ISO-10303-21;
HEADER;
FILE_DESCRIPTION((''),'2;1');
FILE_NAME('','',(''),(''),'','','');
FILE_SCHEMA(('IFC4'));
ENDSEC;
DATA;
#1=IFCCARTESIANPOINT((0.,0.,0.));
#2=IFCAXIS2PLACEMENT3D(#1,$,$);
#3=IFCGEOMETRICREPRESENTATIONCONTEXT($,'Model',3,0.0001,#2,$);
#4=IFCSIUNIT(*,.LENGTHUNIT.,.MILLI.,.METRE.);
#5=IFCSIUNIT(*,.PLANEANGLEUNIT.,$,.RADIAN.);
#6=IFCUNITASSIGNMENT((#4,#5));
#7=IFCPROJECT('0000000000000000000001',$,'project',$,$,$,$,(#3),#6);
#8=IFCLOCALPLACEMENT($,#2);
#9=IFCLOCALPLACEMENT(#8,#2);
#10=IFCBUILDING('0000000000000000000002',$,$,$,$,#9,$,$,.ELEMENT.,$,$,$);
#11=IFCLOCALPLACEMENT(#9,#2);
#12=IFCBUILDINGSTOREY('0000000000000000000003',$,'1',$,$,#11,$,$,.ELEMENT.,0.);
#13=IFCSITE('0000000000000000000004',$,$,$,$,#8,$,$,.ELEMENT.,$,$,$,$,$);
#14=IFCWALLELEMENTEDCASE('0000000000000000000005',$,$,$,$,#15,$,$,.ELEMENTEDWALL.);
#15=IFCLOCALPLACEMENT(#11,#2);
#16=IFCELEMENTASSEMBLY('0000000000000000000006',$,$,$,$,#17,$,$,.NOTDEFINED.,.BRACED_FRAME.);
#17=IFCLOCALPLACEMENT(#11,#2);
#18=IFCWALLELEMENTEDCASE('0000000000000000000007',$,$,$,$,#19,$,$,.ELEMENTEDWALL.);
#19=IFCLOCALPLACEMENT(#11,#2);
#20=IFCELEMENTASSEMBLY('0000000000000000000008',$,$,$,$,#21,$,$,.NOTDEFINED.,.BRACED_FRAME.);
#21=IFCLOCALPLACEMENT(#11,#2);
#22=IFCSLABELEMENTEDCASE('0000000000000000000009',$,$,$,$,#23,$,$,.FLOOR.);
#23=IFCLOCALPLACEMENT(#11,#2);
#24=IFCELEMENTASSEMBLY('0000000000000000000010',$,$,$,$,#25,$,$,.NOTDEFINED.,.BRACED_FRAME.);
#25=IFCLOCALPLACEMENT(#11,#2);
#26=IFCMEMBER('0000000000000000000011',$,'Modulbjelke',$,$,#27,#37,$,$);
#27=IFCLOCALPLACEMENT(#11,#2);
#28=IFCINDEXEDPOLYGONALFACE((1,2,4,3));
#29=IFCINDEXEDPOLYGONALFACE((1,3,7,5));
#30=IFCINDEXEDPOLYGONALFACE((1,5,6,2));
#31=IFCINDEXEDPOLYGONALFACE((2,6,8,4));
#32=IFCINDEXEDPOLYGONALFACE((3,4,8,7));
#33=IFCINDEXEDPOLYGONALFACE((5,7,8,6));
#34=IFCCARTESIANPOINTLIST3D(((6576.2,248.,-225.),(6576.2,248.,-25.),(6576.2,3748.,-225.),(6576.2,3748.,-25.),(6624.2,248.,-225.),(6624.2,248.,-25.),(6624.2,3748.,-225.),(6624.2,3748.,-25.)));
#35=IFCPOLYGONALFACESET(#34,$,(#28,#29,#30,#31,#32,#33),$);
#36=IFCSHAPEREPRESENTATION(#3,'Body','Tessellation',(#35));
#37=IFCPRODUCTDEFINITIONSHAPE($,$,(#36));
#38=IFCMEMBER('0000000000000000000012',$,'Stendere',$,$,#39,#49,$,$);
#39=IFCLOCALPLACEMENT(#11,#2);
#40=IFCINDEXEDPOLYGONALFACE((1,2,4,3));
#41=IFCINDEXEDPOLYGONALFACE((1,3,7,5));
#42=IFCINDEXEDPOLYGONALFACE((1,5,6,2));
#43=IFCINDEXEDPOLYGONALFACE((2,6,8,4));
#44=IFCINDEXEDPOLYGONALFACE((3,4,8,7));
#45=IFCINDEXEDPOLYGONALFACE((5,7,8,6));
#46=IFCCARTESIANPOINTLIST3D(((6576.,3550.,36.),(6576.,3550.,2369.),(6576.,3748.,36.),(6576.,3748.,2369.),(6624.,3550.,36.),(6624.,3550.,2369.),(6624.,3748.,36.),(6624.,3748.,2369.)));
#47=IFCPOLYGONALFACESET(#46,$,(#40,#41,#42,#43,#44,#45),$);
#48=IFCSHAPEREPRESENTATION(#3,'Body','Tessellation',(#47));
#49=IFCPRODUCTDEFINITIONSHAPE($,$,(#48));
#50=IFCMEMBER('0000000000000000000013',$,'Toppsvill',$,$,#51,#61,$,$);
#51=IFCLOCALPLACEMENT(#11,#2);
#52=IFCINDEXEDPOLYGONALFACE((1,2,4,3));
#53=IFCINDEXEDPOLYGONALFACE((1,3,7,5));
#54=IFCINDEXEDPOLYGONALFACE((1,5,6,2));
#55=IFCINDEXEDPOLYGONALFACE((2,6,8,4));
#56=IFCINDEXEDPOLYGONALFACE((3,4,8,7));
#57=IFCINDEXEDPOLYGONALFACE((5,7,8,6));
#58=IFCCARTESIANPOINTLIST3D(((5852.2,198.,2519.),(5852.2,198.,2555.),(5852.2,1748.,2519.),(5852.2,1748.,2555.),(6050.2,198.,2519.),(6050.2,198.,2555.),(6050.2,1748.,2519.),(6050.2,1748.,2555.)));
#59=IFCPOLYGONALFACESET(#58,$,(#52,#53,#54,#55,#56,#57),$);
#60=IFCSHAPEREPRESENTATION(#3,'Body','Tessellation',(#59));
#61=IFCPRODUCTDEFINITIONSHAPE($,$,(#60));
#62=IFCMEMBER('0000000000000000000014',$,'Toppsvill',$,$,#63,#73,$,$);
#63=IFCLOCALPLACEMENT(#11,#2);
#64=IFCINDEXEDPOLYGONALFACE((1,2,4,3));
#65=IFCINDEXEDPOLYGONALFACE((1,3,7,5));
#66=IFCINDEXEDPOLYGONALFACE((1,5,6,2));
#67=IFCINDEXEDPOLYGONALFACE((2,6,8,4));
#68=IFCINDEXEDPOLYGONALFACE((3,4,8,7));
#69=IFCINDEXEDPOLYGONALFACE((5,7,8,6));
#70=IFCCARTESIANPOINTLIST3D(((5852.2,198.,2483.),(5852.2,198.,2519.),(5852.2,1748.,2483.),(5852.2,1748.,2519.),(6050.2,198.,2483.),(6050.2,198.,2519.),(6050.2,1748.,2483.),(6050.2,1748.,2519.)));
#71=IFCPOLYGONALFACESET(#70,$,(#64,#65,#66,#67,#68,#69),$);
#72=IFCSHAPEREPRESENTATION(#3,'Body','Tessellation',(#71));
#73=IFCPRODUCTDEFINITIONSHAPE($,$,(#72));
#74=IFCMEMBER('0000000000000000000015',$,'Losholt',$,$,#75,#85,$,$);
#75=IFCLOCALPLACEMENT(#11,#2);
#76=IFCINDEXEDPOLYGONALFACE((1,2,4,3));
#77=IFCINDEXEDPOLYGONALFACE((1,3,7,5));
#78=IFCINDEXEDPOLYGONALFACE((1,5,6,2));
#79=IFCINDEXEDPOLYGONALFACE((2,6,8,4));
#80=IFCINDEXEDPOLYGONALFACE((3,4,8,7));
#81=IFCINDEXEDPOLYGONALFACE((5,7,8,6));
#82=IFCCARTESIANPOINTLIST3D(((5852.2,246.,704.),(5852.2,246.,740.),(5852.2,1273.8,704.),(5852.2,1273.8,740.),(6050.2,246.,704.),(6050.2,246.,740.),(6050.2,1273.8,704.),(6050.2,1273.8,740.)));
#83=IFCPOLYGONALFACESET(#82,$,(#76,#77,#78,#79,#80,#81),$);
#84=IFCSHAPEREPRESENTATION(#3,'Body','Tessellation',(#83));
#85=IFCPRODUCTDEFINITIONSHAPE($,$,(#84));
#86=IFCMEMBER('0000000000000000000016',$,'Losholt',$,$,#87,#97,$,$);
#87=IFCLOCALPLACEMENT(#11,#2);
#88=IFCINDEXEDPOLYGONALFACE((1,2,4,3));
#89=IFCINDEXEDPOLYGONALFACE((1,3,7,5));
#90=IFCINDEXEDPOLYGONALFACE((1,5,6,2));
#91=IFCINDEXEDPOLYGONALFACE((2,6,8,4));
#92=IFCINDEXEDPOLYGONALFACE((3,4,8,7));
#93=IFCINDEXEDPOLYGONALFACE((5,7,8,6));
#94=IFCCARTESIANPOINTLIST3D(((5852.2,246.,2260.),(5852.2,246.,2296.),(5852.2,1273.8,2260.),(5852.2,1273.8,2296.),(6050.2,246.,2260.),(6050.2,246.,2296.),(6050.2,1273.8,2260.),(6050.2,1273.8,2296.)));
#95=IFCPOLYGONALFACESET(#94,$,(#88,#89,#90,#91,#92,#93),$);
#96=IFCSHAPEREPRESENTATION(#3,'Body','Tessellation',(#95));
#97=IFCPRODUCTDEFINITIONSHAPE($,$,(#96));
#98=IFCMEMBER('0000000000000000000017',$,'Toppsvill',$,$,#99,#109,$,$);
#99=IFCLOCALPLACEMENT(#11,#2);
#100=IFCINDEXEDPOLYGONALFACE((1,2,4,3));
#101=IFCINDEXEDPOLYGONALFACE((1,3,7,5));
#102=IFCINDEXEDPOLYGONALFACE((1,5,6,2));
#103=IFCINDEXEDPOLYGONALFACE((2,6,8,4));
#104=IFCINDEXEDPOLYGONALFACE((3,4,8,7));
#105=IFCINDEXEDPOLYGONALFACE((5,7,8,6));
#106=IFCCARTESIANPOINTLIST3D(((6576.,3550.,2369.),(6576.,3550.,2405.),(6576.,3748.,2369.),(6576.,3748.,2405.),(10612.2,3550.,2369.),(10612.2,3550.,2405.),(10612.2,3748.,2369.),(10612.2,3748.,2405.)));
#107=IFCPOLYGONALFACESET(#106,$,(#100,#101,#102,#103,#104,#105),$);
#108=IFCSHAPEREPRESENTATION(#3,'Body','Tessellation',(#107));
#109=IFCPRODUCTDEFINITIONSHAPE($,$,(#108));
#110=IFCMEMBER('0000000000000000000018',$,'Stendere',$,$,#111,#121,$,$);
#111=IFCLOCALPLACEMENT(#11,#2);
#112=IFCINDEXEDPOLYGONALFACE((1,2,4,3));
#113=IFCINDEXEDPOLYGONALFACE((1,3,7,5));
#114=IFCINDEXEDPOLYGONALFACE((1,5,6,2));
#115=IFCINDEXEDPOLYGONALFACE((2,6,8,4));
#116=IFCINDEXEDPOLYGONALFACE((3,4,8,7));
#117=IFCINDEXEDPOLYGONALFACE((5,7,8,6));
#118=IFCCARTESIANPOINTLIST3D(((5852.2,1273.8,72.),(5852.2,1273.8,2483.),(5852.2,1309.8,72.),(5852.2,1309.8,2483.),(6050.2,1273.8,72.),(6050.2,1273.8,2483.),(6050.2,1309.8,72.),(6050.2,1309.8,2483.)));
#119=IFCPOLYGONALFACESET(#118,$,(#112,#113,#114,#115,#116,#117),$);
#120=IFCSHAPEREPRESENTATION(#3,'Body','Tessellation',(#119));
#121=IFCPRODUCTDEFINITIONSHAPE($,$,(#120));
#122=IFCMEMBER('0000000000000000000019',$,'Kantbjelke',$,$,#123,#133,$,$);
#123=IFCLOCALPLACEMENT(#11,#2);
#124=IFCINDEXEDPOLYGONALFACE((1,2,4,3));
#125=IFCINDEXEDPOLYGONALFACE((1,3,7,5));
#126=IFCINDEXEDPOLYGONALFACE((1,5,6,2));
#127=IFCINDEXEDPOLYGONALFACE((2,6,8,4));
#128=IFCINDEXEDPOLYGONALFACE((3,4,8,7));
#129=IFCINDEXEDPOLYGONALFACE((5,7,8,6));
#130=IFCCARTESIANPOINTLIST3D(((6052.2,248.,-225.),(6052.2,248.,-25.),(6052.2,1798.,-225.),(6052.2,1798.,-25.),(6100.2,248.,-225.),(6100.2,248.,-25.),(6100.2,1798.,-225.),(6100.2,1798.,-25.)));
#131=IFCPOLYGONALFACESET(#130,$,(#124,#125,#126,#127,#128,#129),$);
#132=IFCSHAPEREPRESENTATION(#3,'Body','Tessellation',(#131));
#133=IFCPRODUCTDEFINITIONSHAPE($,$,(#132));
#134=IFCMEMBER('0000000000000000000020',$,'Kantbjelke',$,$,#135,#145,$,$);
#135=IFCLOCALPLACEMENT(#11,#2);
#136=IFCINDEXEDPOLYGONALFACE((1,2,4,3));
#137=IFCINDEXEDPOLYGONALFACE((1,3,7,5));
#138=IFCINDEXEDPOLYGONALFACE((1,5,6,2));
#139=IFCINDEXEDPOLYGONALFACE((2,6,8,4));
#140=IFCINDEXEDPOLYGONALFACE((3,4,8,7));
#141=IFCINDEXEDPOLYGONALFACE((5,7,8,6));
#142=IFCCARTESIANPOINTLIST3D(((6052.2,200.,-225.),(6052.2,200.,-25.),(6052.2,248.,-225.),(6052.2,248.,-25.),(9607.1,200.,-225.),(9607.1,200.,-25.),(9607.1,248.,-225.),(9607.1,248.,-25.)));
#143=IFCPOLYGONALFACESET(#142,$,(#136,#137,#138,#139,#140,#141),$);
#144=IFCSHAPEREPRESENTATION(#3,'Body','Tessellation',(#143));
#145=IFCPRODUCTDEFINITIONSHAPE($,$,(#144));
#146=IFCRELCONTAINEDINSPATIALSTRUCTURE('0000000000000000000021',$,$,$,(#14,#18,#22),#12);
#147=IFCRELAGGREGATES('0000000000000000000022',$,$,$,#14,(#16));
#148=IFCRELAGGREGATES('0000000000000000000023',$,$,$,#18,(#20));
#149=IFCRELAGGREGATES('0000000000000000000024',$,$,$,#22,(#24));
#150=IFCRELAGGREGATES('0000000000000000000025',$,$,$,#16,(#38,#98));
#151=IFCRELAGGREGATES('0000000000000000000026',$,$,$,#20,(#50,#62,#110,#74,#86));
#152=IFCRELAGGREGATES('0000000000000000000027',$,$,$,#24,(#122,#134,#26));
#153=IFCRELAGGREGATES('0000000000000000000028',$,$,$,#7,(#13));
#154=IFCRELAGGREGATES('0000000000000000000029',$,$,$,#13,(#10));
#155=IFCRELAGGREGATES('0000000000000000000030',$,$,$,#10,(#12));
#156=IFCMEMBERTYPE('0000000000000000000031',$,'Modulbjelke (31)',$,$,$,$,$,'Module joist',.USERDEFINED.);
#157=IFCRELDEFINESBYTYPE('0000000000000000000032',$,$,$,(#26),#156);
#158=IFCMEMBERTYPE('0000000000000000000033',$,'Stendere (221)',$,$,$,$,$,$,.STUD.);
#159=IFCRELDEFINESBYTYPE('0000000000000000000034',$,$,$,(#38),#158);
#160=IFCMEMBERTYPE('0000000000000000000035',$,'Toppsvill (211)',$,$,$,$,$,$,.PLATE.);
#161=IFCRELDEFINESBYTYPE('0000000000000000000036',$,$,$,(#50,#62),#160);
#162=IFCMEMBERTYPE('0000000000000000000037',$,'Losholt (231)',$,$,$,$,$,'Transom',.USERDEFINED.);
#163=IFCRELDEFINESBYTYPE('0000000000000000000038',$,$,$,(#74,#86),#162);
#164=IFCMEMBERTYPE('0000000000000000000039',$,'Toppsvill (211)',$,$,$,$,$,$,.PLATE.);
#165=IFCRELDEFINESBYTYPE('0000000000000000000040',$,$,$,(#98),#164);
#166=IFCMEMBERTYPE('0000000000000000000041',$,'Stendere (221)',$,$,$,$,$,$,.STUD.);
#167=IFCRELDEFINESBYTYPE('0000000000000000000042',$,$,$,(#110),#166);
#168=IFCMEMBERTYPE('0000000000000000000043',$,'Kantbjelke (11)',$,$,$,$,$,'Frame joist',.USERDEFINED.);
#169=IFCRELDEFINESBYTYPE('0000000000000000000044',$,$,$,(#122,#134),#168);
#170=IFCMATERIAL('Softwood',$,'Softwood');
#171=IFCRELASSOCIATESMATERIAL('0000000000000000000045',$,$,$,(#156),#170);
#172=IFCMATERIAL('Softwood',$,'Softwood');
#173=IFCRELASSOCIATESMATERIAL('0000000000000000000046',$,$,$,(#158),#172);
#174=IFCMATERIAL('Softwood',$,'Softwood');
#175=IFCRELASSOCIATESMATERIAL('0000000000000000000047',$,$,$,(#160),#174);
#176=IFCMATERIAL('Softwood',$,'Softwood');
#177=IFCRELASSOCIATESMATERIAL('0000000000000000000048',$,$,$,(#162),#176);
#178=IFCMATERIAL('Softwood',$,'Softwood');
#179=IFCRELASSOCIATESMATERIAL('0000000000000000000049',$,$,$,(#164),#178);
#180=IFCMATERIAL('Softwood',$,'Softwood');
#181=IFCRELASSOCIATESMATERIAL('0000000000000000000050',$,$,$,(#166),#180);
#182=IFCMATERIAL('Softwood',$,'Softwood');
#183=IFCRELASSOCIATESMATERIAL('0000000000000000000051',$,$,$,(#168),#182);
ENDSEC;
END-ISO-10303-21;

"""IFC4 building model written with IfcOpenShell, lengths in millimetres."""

from ifc_helpers import new_model, si_unit, frame, origin, place, context, project, spatial, rectangle, extrude, material, material_profile, profile_set, type_object, element, aggregate, save


model = new_model("IFC4")

# Units and contexts
model_context = context("Model", 3, precision=0.0001, world=origin())
ifc_project = project(units=[si_unit("LENGTHUNIT", "METRE", prefix="MILLI"), si_unit("PLANEANGLEUNIT", "RADIAN")], contexts=[model_context])

# Site, building, storey
site_placement = place(None, origin())
site = spatial("IfcSite", under=ifc_project, at=site_placement, CompositionType="ELEMENT")
building_placement = place(site_placement, origin())
building = spatial("IfcBuilding", under=site, at=building_placement, CompositionType="ELEMENT")
storey_placement = place(building_placement, origin())
storey = spatial("IfcBuildingStorey", under=building, at=storey_placement, Name="1", CompositionType="ELEMENT", Elevation=0.0)

# Wall, element assembly
wall_1_placement = place(storey_placement, frame((6576.0, 3748.0, 0.0), z_axis=(0.0, -1.0, 0.0)))
wall_1 = element("IfcWallElementedCase", 1, at=wall_1_placement, inside=storey, PredefinedType="ELEMENTEDWALL")
assembly_1_placement = place(wall_1_placement, origin())
assembly_1 = element("IfcElementAssembly", 2, at=assembly_1_placement, AssemblyPlace="NOTDEFINED", PredefinedType="BRACED_FRAME")
aggregate(wall_1, [assembly_1])

# Wall, element assembly
wall_2_placement = place(storey_placement, frame((6050.2, 1748.0, 0.0), z_axis=(-1.0, 0.0, 0.0), x_axis=(0.0, -1.0, 0.0)))
wall_2 = element("IfcWallElementedCase", 3, at=wall_2_placement, inside=storey, PredefinedType="ELEMENTEDWALL")
assembly_2_placement = place(wall_2_placement, origin())
assembly_2 = element("IfcElementAssembly", 4, at=assembly_2_placement, AssemblyPlace="NOTDEFINED", PredefinedType="BRACED_FRAME")
aggregate(wall_2, [assembly_2])

# Slab, element assembly, member
slab_placement = place(storey_placement, origin())
slab = element("IfcSlabElementedCase", 5, at=slab_placement, inside=storey, PredefinedType="FLOOR")
assembly_3_placement = place(slab_placement, frame((0.0, 0.0, -225.0)))
assembly_3 = element("IfcElementAssembly", 6, at=assembly_3_placement, AssemblyPlace="NOTDEFINED", PredefinedType="BRACED_FRAME")
aggregate(slab, [assembly_3])
ifc_material_1 = material(Name="Softwood", Category="Softwood")
ifc_material_profile_1 = material_profile(ifc_material_1, rectangle(XDim=48.0, YDim=200.0), Name="Modulbjelke (31)")
ifc_profile_set_1 = profile_set([ifc_material_profile_1])
member_type_1 = type_object("IfcMemberType", Name="Modulbjelke (31)", ElementType="Module joist", PredefinedType="USERDEFINED", material=ifc_profile_set_1)
member_1_placement = place(assembly_3_placement, frame((6600.2, 248.0, 0.0), z_axis=(0.0, 1.0, 0.0), x_axis=(-1.0, 0.0, 0.0)))
member_1 = element("IfcMember", 7, at=member_1_placement, type_object=member_type_1, Name="Modulbjelke", context=model_context, shape_type="SweptSolid", body=[
    extrude(rectangle(XDim=48.0, YDim=200.0), frame((0.0, 100.0, 0.0)), (0.0, 0.0, 1.0), 3500.0),
])

# Members
ifc_material_2 = material(Name="Softwood", Category="Softwood")
ifc_material_profile_2 = material_profile(ifc_material_2, rectangle(XDim=48.0, YDim=198.0), Name="Stendere (221)")
ifc_profile_set_2 = profile_set([ifc_material_profile_2])
member_type_2 = type_object("IfcMemberType", Name="Stendere (221)", PredefinedType="STUD", material=ifc_profile_set_2)
member_2_placement = place(assembly_1_placement, frame((24.0, 36.0, 0.0), z_axis=(0.0, 1.0, 0.0), x_axis=(-1.0, 0.0, 0.0)))
member_2 = element("IfcMember", 8, at=member_2_placement, type_object=member_type_2, Name="Stendere", context=model_context, shape_type="SweptSolid", body=[
    extrude(rectangle(XDim=48.0, YDim=198.0), frame((0.0, 99.0, 0.0)), (0.0, 0.0, 1.0), 2333.0),
])
ifc_material_3 = material(Name="Softwood", Category="Softwood")
ifc_material_profile_3 = material_profile(ifc_material_3, rectangle(XDim=36.0, YDim=198.0), Name="Toppsvill (211)")
ifc_profile_set_3 = profile_set([ifc_material_profile_3])
member_type_3 = type_object("IfcMemberType", Name="Toppsvill (211)", PredefinedType="PLATE", material=ifc_profile_set_3)
member_3_placement = place(assembly_2_placement, frame((0.0, 2537.0, 0.0), z_axis=(1.0, 0.0, 0.0), x_axis=(0.0, 1.0, 0.0)))
member_3 = element("IfcMember", 9, at=member_3_placement, type_object=member_type_3, Name="Toppsvill", context=model_context, shape_type="SweptSolid", body=[
    extrude(rectangle(XDim=36.0, YDim=198.0), frame((0.0, 99.0, 0.0)), (0.0, 0.0, 1.0), 1550.0),
])
member_4_placement = place(assembly_2_placement, frame((0.0, 2501.0, 0.0), z_axis=(1.0, 0.0, 0.0), x_axis=(0.0, 1.0, 0.0)))
member_4 = element("IfcMember", 10, at=member_4_placement, type_object=member_type_3, Name="Toppsvill", context=model_context, shape_type="SweptSolid", body=[
    extrude(rectangle(XDim=36.0, YDim=198.0), frame((0.0, 99.0, 0.0)), (0.0, 0.0, 1.0), 1550.0),
])

# Shared definitions
ifc_material_4 = material(Name="Softwood", Category="Softwood")
ifc_material_profile_4 = material_profile(ifc_material_4, rectangle(XDim=36.0, YDim=198.0), Name="Losholt (231)")
ifc_profile_set_4 = profile_set([ifc_material_profile_4])
member_type_4 = type_object("IfcMemberType", Name="Losholt (231)", ElementType="Transom", PredefinedType="USERDEFINED", material=ifc_profile_set_4)

# Members
member_5_placement = place(assembly_2_placement, frame((474.2, 722.0, 0.0), z_axis=(1.0, 0.0, 0.0), x_axis=(0.0, 1.0, 0.0)))
member_5 = element("IfcMember", 11, at=member_5_placement, type_object=member_type_4, Name="Losholt", context=model_context, shape_type="SweptSolid", body=[
    extrude(rectangle(XDim=36.0, YDim=198.0), frame((0.0, 99.0, 0.0)), (0.0, 0.0, 1.0), 1027.8),
])
member_6_placement = place(assembly_2_placement, frame((474.2, 2278.0, 0.0), z_axis=(1.0, 0.0, 0.0), x_axis=(0.0, 1.0, 0.0)))
member_6 = element("IfcMember", 12, at=member_6_placement, type_object=member_type_4, Name="Losholt", context=model_context, shape_type="SweptSolid", body=[
    extrude(rectangle(XDim=36.0, YDim=198.0), frame((0.0, 99.0, 0.0)), (0.0, 0.0, 1.0), 1027.8),
])
ifc_material_5 = material(Name="Softwood", Category="Softwood")
ifc_material_profile_5 = material_profile(ifc_material_5, rectangle(XDim=36.0, YDim=198.0), Name="Toppsvill (211)")
ifc_profile_set_5 = profile_set([ifc_material_profile_5])
member_type_5 = type_object("IfcMemberType", Name="Toppsvill (211)", PredefinedType="PLATE", material=ifc_profile_set_5)
member_7_placement = place(assembly_1_placement, frame((0.0, 2387.0, 0.0), z_axis=(1.0, 0.0, 0.0), x_axis=(0.0, 1.0, 0.0)))
member_7 = element("IfcMember", 13, at=member_7_placement, type_object=member_type_5, Name="Toppsvill", context=model_context, shape_type="SweptSolid", body=[
    extrude(rectangle(XDim=36.0, YDim=198.0), frame((0.0, 99.0, 0.0)), (0.0, 0.0, 1.0), 4036.2),
])
aggregate(assembly_1, [member_2, member_7])
ifc_material_6 = material(Name="Softwood", Category="Softwood")
ifc_material_profile_6 = material_profile(ifc_material_6, rectangle(XDim=36.0, YDim=198.0), Name="Stendere (221)")
ifc_profile_set_6 = profile_set([ifc_material_profile_6])
member_type_6 = type_object("IfcMemberType", Name="Stendere (221)", PredefinedType="STUD", material=ifc_profile_set_6)
member_8_placement = place(assembly_2_placement, frame((456.2, 72.0, 0.0), z_axis=(0.0, 1.0, 0.0), x_axis=(-1.0, 0.0, 0.0)))
member_8 = element("IfcMember", 14, at=member_8_placement, type_object=member_type_6, Name="Stendere", context=model_context, shape_type="SweptSolid", body=[
    extrude(rectangle(XDim=36.0, YDim=198.0), frame((0.0, 99.0, 0.0)), (0.0, 0.0, 1.0), 2411.0),
])
aggregate(assembly_2, [member_3, member_4, member_8, member_5, member_6])
ifc_material_7 = material(Name="Softwood", Category="Softwood")
ifc_material_profile_7 = material_profile(ifc_material_7, rectangle(XDim=48.0, YDim=200.0), Name="Kantbjelke (11)")
ifc_profile_set_7 = profile_set([ifc_material_profile_7])
member_type_7 = type_object("IfcMemberType", Name="Kantbjelke (11)", ElementType="Frame joist", PredefinedType="USERDEFINED", material=ifc_profile_set_7)
member_9_placement = place(assembly_3_placement, frame((6076.2, 1798.0, 0.0), z_axis=(0.0, -1.0, 0.0)))
member_9 = element("IfcMember", 15, at=member_9_placement, type_object=member_type_7, Name="Kantbjelke", context=model_context, shape_type="SweptSolid", body=[
    extrude(rectangle(XDim=48.0, YDim=200.0), frame((0.0, 100.0, 0.0)), (0.0, 0.0, 1.0), 1550.0),
])
member_10_placement = place(assembly_3_placement, frame((6052.2, 224.0, 0.0), z_axis=(1.0, 0.0, 0.0), x_axis=(0.0, 1.0, 0.0)))
member_10 = element("IfcMember", 16, at=member_10_placement, type_object=member_type_7, Name="Kantbjelke", context=model_context, shape_type="SweptSolid", body=[
    extrude(rectangle(XDim=48.0, YDim=200.0), frame((0.0, 100.0, 0.0)), (0.0, 0.0, 1.0), 3554.9),
])
aggregate(assembly_3, [member_9, member_10, member_1])

save(model, "model.ifc")
